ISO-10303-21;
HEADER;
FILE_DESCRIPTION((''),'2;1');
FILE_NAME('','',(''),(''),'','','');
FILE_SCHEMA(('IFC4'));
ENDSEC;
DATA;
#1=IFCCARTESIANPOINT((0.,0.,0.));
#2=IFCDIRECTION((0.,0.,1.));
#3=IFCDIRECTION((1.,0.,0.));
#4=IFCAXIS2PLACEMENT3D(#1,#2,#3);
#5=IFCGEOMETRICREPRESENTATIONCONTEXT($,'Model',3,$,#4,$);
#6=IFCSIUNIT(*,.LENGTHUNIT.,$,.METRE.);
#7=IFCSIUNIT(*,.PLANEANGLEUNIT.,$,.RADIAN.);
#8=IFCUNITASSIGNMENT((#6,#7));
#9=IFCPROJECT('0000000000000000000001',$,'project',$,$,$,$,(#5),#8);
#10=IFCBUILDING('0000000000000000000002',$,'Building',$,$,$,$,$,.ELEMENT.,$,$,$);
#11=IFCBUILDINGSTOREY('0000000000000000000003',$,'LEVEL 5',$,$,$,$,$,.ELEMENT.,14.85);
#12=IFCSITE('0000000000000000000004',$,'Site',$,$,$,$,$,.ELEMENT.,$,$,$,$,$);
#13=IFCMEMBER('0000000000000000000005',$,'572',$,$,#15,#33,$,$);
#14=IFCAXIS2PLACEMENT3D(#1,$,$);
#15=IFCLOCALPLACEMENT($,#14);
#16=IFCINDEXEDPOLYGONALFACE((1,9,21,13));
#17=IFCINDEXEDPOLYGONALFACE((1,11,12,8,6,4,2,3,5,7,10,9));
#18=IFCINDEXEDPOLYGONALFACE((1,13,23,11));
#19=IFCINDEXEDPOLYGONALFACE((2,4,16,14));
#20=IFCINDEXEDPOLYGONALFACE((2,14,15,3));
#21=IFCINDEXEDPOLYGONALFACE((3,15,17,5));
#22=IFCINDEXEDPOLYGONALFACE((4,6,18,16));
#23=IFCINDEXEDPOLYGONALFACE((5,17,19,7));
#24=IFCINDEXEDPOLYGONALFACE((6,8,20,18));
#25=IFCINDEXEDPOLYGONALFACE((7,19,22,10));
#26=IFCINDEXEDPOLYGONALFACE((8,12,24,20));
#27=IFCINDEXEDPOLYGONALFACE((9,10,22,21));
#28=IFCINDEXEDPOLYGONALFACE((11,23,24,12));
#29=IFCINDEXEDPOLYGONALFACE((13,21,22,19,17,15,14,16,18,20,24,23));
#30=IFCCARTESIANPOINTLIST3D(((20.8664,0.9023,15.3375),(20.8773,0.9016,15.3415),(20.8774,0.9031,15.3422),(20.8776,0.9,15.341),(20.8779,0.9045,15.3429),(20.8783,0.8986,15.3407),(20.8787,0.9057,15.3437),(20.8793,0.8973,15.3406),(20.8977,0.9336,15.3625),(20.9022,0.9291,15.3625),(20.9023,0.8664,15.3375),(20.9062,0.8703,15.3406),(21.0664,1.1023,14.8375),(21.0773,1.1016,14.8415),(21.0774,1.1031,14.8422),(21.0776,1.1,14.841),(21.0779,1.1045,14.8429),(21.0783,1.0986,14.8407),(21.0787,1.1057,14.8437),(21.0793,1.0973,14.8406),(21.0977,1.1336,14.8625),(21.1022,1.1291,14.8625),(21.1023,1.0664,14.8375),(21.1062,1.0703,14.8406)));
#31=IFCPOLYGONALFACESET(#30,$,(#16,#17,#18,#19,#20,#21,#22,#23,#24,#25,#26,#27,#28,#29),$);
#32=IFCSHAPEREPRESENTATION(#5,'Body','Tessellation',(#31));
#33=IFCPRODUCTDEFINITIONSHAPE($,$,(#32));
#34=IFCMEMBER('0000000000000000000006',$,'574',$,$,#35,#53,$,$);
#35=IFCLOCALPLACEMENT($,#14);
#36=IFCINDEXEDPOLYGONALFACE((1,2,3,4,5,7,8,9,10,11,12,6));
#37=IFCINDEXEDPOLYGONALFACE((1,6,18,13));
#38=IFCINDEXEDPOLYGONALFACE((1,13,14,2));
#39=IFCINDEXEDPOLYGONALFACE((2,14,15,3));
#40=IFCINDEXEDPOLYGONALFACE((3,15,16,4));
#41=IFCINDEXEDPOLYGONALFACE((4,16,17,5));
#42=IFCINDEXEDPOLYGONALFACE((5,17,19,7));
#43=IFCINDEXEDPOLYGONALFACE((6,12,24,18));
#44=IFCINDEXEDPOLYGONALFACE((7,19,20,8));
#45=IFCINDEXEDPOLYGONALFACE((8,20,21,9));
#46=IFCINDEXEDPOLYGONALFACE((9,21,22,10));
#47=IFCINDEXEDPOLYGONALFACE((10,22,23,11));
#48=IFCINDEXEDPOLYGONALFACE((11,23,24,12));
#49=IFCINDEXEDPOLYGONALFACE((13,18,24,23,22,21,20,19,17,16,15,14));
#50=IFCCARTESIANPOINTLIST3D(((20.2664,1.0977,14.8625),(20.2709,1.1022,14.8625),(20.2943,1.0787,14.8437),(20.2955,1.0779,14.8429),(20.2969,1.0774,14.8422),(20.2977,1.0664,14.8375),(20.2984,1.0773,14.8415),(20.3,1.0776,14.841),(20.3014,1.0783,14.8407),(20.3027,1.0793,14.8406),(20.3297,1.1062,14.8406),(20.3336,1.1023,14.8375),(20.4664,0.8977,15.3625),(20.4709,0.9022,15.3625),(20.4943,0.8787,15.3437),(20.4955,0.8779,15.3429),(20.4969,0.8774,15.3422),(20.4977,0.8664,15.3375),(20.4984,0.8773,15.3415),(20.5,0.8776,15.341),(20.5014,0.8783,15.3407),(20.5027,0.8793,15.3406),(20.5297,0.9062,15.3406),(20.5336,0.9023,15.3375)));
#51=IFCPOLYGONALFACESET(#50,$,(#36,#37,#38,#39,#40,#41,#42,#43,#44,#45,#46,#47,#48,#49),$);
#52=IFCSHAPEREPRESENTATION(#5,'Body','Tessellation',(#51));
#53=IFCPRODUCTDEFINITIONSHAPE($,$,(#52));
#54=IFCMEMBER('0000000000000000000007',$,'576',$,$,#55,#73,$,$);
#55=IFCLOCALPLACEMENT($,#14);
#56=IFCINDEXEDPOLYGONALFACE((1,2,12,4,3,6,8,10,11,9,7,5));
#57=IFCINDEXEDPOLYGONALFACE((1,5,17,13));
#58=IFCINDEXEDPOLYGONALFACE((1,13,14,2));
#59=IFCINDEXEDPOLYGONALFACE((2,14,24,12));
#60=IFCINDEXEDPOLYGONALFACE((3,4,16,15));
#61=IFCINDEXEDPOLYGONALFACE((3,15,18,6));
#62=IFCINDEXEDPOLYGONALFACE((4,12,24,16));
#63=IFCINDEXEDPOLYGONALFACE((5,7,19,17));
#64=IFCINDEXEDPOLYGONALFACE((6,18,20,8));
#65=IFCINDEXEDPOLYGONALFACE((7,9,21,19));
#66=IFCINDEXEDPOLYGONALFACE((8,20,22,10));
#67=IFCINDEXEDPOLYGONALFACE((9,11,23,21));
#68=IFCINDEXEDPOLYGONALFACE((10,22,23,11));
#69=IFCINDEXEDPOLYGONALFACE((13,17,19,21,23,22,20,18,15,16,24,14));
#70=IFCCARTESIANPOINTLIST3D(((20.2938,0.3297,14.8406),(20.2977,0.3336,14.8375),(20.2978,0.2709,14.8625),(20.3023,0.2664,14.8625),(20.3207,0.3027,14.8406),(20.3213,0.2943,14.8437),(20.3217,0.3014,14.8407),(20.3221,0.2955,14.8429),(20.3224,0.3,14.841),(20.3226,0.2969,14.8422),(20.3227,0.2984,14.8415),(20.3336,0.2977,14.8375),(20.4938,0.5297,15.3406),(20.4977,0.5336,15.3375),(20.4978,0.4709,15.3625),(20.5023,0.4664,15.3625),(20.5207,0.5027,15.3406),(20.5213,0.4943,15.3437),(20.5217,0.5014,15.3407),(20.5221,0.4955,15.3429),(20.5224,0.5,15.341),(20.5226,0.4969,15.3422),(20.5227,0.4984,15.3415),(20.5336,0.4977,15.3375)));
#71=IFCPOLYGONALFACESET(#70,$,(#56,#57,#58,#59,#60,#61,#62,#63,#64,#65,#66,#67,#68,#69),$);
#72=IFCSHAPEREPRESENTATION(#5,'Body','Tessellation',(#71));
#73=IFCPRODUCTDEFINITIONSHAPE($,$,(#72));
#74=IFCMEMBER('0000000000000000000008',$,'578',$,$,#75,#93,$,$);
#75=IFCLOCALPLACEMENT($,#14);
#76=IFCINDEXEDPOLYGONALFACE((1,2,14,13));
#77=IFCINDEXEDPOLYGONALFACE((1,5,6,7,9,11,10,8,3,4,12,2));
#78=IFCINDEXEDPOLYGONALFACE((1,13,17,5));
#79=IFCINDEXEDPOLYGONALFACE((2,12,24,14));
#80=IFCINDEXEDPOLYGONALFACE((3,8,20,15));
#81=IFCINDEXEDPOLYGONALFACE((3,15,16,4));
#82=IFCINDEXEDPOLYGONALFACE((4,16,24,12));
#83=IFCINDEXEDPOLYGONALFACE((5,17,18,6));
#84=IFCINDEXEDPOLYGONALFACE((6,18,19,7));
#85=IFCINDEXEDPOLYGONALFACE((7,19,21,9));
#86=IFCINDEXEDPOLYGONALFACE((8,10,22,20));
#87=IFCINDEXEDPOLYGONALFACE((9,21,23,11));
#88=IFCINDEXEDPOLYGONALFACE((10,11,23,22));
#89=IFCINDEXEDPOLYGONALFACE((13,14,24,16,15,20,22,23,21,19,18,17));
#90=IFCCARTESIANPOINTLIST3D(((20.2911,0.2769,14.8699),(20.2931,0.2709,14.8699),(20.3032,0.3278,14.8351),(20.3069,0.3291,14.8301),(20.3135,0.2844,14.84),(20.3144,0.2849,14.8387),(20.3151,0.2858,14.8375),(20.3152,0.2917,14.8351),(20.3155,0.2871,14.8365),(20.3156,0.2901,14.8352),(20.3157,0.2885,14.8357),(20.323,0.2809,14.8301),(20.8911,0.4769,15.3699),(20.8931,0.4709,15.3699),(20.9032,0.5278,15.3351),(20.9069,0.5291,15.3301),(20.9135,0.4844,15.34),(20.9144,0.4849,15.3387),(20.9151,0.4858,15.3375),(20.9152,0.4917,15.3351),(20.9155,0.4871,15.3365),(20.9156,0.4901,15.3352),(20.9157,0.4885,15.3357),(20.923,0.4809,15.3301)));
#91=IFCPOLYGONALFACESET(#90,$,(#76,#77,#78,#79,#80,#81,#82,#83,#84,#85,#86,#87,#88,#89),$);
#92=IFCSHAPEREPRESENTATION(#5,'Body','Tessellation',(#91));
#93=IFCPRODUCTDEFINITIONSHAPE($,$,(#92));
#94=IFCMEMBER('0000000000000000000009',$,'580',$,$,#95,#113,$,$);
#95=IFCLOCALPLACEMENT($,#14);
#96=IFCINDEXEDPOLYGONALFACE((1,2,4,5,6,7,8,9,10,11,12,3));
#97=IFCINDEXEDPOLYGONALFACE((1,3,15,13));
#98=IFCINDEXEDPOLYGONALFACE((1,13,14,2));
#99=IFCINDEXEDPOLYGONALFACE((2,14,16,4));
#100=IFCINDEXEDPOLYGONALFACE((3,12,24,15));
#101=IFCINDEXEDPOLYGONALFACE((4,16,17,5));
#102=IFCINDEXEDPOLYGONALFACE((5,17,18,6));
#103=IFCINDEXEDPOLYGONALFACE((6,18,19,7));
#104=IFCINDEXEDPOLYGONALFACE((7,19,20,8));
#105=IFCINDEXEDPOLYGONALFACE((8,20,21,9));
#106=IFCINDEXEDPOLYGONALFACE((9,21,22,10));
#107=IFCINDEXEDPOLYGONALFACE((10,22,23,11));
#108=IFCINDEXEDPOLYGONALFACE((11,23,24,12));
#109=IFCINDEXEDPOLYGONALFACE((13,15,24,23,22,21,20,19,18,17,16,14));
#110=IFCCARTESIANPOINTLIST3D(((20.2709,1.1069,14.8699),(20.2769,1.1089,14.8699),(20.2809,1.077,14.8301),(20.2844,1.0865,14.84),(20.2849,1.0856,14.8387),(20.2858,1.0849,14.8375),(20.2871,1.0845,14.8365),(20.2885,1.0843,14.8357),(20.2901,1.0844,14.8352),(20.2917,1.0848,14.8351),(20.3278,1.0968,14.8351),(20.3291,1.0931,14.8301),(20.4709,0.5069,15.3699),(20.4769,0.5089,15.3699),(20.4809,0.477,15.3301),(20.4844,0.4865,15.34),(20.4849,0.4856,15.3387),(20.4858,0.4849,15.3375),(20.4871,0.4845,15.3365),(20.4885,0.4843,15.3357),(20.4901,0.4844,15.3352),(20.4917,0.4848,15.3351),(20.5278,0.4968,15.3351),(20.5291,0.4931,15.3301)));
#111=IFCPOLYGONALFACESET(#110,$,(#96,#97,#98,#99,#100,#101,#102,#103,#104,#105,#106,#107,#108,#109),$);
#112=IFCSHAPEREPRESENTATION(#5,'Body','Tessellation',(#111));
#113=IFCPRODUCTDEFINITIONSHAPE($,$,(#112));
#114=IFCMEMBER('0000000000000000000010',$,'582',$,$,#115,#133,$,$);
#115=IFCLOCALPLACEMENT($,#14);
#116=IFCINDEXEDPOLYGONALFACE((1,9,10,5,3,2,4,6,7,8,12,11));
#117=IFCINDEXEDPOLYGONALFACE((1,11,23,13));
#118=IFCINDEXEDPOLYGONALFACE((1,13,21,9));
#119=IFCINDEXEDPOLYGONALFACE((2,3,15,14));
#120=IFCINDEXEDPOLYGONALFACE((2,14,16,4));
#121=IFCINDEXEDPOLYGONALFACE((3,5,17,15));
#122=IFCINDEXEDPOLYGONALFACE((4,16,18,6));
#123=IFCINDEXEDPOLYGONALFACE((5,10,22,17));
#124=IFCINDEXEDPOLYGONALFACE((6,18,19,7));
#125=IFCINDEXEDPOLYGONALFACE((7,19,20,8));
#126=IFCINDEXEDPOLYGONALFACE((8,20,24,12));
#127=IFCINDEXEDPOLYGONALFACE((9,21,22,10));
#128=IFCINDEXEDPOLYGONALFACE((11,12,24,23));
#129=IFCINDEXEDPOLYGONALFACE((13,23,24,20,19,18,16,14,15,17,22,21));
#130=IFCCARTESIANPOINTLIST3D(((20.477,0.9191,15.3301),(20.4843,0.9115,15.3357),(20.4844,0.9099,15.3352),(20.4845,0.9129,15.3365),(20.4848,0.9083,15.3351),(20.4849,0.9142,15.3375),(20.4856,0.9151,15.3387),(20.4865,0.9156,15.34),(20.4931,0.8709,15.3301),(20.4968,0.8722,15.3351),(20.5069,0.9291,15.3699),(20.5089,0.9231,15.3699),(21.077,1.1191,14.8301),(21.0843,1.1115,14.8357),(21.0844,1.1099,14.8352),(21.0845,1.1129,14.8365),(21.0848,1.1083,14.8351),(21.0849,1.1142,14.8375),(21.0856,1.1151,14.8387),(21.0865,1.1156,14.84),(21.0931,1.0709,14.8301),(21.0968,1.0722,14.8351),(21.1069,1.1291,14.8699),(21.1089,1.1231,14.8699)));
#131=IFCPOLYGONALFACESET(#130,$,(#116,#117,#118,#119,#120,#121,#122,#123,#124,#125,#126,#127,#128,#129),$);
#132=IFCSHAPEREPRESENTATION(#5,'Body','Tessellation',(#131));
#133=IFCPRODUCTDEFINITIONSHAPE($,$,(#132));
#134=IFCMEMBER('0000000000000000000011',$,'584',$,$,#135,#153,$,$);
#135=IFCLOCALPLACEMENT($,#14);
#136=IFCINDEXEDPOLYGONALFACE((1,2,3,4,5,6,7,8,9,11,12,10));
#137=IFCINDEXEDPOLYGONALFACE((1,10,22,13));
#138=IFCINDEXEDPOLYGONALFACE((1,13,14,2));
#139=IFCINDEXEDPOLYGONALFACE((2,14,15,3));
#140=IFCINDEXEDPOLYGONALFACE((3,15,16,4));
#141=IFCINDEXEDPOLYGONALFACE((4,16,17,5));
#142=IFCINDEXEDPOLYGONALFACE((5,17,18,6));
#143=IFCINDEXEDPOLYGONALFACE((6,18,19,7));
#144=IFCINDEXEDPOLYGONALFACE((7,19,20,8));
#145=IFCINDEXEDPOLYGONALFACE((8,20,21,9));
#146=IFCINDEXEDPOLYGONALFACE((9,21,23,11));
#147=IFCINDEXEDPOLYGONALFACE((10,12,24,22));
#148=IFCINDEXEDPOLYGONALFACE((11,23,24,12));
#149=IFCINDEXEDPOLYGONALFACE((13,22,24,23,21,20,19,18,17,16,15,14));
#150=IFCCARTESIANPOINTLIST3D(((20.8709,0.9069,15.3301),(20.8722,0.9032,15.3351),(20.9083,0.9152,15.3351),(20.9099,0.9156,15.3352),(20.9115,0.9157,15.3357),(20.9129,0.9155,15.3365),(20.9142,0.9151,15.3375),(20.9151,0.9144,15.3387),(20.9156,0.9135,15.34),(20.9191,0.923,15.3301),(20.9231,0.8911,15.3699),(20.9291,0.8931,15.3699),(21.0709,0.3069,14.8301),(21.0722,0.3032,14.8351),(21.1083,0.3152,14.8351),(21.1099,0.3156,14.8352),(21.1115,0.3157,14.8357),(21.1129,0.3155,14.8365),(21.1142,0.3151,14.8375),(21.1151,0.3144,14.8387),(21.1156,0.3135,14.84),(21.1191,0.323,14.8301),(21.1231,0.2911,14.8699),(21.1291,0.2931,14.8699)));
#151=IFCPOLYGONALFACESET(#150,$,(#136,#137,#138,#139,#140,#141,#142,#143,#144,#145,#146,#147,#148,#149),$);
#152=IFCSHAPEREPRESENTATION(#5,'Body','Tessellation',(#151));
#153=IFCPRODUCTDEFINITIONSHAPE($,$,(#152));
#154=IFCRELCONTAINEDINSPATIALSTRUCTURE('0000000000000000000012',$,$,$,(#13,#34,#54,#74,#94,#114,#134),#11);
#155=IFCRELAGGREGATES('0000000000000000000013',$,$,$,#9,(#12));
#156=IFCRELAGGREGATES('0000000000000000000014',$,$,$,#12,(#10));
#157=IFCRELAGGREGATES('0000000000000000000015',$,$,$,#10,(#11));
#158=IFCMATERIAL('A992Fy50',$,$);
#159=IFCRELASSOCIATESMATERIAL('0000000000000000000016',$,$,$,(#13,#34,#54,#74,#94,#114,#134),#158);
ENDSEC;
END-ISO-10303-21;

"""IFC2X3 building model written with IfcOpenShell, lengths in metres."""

from ifc_helpers import new_model, si_unit, frame, origin_with_axes, origin_2d_with_axis, place, context, project, spatial, l_section, extrude, material, element, save


model = new_model("IFC2X3")

# Units and contexts
model_context = context("Model", 3, world=origin_with_axes())
ifc_project = project(units=[si_unit("LENGTHUNIT", "METRE"), si_unit("PLANEANGLEUNIT", "RADIAN")], contexts=[model_context])

# Site, building, storey
site = spatial("IfcSite", under=ifc_project, Name="Site", CompositionType="ELEMENT")
building = spatial("IfcBuilding", under=site, Name="Building", CompositionType="ELEMENT")
storey = spatial("IfcBuildingStorey", under=building, Name="LEVEL 5", CompositionType="ELEMENT", Elevation=14.85)

# Shared definitions
ifc_material = material(Name="A992Fy50")

# Members
for number, where, z_axis, x_axis, name in (
    (1, (21.1, 1.1, 14.85), (-0.348155, -0.348155, 0.870388), (0.707107, -0.707107, 0.0), "572"),
    (2, (20.3, 1.1, 14.85), (0.348155, -0.348155, 0.870388), (0.707107, 0.707107, 0.0), "574"),
    (3, (20.3, 0.3, 14.85), (0.348155, 0.348155, 0.870388), (-0.707107, 0.707107, 0.0), "576"),
):
    element("IfcMember", number, at=place(None, frame(where, z_axis=z_axis, x_axis=x_axis)), inside=storey, material=ifc_material, Name=name, context=model_context, shape_type="SweptSolid", body=[
        extrude(l_section(Depth=0.0508, Width=0.0508, Thickness=0.0063, FilletRadius=0.0063, at=origin_2d_with_axis()), origin_with_axes(), (0.0, 0.0, 1.0), 0.5745),
    ])
for number, where, z_axis, x_axis, name in (
    (4, (20.3, 0.3, 14.85), (0.744208, 0.248069, 0.620174), (-0.316228, 0.948683, 0.0), "578"),
    (5, (20.3, 1.1, 14.85), (0.248069, -0.744208, 0.620174), (0.948683, 0.316228, 0.0), "580"),
    (6, (21.1, 1.1, 14.85), (-0.744208, -0.248069, 0.620174), (0.316228, -0.948683, 0.0), "582"),
    (7, (21.1, 0.3, 14.85), (-0.248069, 0.744208, 0.620174), (-0.948683, -0.316228, 0.0), "584"),
):
    element("IfcMember", number, at=place(None, frame(where, z_axis=z_axis, x_axis=x_axis)), inside=storey, material=ifc_material, Name=name, context=model_context, shape_type="SweptSolid", body=[
        extrude(l_section(Depth=0.0508, Width=0.0508, Thickness=0.0063, FilletRadius=0.0063, at=origin_2d_with_axis()), origin_with_axes(), (0.0, 0.0, 1.0), 0.8062),
    ])

save(model, "model.ifc")
